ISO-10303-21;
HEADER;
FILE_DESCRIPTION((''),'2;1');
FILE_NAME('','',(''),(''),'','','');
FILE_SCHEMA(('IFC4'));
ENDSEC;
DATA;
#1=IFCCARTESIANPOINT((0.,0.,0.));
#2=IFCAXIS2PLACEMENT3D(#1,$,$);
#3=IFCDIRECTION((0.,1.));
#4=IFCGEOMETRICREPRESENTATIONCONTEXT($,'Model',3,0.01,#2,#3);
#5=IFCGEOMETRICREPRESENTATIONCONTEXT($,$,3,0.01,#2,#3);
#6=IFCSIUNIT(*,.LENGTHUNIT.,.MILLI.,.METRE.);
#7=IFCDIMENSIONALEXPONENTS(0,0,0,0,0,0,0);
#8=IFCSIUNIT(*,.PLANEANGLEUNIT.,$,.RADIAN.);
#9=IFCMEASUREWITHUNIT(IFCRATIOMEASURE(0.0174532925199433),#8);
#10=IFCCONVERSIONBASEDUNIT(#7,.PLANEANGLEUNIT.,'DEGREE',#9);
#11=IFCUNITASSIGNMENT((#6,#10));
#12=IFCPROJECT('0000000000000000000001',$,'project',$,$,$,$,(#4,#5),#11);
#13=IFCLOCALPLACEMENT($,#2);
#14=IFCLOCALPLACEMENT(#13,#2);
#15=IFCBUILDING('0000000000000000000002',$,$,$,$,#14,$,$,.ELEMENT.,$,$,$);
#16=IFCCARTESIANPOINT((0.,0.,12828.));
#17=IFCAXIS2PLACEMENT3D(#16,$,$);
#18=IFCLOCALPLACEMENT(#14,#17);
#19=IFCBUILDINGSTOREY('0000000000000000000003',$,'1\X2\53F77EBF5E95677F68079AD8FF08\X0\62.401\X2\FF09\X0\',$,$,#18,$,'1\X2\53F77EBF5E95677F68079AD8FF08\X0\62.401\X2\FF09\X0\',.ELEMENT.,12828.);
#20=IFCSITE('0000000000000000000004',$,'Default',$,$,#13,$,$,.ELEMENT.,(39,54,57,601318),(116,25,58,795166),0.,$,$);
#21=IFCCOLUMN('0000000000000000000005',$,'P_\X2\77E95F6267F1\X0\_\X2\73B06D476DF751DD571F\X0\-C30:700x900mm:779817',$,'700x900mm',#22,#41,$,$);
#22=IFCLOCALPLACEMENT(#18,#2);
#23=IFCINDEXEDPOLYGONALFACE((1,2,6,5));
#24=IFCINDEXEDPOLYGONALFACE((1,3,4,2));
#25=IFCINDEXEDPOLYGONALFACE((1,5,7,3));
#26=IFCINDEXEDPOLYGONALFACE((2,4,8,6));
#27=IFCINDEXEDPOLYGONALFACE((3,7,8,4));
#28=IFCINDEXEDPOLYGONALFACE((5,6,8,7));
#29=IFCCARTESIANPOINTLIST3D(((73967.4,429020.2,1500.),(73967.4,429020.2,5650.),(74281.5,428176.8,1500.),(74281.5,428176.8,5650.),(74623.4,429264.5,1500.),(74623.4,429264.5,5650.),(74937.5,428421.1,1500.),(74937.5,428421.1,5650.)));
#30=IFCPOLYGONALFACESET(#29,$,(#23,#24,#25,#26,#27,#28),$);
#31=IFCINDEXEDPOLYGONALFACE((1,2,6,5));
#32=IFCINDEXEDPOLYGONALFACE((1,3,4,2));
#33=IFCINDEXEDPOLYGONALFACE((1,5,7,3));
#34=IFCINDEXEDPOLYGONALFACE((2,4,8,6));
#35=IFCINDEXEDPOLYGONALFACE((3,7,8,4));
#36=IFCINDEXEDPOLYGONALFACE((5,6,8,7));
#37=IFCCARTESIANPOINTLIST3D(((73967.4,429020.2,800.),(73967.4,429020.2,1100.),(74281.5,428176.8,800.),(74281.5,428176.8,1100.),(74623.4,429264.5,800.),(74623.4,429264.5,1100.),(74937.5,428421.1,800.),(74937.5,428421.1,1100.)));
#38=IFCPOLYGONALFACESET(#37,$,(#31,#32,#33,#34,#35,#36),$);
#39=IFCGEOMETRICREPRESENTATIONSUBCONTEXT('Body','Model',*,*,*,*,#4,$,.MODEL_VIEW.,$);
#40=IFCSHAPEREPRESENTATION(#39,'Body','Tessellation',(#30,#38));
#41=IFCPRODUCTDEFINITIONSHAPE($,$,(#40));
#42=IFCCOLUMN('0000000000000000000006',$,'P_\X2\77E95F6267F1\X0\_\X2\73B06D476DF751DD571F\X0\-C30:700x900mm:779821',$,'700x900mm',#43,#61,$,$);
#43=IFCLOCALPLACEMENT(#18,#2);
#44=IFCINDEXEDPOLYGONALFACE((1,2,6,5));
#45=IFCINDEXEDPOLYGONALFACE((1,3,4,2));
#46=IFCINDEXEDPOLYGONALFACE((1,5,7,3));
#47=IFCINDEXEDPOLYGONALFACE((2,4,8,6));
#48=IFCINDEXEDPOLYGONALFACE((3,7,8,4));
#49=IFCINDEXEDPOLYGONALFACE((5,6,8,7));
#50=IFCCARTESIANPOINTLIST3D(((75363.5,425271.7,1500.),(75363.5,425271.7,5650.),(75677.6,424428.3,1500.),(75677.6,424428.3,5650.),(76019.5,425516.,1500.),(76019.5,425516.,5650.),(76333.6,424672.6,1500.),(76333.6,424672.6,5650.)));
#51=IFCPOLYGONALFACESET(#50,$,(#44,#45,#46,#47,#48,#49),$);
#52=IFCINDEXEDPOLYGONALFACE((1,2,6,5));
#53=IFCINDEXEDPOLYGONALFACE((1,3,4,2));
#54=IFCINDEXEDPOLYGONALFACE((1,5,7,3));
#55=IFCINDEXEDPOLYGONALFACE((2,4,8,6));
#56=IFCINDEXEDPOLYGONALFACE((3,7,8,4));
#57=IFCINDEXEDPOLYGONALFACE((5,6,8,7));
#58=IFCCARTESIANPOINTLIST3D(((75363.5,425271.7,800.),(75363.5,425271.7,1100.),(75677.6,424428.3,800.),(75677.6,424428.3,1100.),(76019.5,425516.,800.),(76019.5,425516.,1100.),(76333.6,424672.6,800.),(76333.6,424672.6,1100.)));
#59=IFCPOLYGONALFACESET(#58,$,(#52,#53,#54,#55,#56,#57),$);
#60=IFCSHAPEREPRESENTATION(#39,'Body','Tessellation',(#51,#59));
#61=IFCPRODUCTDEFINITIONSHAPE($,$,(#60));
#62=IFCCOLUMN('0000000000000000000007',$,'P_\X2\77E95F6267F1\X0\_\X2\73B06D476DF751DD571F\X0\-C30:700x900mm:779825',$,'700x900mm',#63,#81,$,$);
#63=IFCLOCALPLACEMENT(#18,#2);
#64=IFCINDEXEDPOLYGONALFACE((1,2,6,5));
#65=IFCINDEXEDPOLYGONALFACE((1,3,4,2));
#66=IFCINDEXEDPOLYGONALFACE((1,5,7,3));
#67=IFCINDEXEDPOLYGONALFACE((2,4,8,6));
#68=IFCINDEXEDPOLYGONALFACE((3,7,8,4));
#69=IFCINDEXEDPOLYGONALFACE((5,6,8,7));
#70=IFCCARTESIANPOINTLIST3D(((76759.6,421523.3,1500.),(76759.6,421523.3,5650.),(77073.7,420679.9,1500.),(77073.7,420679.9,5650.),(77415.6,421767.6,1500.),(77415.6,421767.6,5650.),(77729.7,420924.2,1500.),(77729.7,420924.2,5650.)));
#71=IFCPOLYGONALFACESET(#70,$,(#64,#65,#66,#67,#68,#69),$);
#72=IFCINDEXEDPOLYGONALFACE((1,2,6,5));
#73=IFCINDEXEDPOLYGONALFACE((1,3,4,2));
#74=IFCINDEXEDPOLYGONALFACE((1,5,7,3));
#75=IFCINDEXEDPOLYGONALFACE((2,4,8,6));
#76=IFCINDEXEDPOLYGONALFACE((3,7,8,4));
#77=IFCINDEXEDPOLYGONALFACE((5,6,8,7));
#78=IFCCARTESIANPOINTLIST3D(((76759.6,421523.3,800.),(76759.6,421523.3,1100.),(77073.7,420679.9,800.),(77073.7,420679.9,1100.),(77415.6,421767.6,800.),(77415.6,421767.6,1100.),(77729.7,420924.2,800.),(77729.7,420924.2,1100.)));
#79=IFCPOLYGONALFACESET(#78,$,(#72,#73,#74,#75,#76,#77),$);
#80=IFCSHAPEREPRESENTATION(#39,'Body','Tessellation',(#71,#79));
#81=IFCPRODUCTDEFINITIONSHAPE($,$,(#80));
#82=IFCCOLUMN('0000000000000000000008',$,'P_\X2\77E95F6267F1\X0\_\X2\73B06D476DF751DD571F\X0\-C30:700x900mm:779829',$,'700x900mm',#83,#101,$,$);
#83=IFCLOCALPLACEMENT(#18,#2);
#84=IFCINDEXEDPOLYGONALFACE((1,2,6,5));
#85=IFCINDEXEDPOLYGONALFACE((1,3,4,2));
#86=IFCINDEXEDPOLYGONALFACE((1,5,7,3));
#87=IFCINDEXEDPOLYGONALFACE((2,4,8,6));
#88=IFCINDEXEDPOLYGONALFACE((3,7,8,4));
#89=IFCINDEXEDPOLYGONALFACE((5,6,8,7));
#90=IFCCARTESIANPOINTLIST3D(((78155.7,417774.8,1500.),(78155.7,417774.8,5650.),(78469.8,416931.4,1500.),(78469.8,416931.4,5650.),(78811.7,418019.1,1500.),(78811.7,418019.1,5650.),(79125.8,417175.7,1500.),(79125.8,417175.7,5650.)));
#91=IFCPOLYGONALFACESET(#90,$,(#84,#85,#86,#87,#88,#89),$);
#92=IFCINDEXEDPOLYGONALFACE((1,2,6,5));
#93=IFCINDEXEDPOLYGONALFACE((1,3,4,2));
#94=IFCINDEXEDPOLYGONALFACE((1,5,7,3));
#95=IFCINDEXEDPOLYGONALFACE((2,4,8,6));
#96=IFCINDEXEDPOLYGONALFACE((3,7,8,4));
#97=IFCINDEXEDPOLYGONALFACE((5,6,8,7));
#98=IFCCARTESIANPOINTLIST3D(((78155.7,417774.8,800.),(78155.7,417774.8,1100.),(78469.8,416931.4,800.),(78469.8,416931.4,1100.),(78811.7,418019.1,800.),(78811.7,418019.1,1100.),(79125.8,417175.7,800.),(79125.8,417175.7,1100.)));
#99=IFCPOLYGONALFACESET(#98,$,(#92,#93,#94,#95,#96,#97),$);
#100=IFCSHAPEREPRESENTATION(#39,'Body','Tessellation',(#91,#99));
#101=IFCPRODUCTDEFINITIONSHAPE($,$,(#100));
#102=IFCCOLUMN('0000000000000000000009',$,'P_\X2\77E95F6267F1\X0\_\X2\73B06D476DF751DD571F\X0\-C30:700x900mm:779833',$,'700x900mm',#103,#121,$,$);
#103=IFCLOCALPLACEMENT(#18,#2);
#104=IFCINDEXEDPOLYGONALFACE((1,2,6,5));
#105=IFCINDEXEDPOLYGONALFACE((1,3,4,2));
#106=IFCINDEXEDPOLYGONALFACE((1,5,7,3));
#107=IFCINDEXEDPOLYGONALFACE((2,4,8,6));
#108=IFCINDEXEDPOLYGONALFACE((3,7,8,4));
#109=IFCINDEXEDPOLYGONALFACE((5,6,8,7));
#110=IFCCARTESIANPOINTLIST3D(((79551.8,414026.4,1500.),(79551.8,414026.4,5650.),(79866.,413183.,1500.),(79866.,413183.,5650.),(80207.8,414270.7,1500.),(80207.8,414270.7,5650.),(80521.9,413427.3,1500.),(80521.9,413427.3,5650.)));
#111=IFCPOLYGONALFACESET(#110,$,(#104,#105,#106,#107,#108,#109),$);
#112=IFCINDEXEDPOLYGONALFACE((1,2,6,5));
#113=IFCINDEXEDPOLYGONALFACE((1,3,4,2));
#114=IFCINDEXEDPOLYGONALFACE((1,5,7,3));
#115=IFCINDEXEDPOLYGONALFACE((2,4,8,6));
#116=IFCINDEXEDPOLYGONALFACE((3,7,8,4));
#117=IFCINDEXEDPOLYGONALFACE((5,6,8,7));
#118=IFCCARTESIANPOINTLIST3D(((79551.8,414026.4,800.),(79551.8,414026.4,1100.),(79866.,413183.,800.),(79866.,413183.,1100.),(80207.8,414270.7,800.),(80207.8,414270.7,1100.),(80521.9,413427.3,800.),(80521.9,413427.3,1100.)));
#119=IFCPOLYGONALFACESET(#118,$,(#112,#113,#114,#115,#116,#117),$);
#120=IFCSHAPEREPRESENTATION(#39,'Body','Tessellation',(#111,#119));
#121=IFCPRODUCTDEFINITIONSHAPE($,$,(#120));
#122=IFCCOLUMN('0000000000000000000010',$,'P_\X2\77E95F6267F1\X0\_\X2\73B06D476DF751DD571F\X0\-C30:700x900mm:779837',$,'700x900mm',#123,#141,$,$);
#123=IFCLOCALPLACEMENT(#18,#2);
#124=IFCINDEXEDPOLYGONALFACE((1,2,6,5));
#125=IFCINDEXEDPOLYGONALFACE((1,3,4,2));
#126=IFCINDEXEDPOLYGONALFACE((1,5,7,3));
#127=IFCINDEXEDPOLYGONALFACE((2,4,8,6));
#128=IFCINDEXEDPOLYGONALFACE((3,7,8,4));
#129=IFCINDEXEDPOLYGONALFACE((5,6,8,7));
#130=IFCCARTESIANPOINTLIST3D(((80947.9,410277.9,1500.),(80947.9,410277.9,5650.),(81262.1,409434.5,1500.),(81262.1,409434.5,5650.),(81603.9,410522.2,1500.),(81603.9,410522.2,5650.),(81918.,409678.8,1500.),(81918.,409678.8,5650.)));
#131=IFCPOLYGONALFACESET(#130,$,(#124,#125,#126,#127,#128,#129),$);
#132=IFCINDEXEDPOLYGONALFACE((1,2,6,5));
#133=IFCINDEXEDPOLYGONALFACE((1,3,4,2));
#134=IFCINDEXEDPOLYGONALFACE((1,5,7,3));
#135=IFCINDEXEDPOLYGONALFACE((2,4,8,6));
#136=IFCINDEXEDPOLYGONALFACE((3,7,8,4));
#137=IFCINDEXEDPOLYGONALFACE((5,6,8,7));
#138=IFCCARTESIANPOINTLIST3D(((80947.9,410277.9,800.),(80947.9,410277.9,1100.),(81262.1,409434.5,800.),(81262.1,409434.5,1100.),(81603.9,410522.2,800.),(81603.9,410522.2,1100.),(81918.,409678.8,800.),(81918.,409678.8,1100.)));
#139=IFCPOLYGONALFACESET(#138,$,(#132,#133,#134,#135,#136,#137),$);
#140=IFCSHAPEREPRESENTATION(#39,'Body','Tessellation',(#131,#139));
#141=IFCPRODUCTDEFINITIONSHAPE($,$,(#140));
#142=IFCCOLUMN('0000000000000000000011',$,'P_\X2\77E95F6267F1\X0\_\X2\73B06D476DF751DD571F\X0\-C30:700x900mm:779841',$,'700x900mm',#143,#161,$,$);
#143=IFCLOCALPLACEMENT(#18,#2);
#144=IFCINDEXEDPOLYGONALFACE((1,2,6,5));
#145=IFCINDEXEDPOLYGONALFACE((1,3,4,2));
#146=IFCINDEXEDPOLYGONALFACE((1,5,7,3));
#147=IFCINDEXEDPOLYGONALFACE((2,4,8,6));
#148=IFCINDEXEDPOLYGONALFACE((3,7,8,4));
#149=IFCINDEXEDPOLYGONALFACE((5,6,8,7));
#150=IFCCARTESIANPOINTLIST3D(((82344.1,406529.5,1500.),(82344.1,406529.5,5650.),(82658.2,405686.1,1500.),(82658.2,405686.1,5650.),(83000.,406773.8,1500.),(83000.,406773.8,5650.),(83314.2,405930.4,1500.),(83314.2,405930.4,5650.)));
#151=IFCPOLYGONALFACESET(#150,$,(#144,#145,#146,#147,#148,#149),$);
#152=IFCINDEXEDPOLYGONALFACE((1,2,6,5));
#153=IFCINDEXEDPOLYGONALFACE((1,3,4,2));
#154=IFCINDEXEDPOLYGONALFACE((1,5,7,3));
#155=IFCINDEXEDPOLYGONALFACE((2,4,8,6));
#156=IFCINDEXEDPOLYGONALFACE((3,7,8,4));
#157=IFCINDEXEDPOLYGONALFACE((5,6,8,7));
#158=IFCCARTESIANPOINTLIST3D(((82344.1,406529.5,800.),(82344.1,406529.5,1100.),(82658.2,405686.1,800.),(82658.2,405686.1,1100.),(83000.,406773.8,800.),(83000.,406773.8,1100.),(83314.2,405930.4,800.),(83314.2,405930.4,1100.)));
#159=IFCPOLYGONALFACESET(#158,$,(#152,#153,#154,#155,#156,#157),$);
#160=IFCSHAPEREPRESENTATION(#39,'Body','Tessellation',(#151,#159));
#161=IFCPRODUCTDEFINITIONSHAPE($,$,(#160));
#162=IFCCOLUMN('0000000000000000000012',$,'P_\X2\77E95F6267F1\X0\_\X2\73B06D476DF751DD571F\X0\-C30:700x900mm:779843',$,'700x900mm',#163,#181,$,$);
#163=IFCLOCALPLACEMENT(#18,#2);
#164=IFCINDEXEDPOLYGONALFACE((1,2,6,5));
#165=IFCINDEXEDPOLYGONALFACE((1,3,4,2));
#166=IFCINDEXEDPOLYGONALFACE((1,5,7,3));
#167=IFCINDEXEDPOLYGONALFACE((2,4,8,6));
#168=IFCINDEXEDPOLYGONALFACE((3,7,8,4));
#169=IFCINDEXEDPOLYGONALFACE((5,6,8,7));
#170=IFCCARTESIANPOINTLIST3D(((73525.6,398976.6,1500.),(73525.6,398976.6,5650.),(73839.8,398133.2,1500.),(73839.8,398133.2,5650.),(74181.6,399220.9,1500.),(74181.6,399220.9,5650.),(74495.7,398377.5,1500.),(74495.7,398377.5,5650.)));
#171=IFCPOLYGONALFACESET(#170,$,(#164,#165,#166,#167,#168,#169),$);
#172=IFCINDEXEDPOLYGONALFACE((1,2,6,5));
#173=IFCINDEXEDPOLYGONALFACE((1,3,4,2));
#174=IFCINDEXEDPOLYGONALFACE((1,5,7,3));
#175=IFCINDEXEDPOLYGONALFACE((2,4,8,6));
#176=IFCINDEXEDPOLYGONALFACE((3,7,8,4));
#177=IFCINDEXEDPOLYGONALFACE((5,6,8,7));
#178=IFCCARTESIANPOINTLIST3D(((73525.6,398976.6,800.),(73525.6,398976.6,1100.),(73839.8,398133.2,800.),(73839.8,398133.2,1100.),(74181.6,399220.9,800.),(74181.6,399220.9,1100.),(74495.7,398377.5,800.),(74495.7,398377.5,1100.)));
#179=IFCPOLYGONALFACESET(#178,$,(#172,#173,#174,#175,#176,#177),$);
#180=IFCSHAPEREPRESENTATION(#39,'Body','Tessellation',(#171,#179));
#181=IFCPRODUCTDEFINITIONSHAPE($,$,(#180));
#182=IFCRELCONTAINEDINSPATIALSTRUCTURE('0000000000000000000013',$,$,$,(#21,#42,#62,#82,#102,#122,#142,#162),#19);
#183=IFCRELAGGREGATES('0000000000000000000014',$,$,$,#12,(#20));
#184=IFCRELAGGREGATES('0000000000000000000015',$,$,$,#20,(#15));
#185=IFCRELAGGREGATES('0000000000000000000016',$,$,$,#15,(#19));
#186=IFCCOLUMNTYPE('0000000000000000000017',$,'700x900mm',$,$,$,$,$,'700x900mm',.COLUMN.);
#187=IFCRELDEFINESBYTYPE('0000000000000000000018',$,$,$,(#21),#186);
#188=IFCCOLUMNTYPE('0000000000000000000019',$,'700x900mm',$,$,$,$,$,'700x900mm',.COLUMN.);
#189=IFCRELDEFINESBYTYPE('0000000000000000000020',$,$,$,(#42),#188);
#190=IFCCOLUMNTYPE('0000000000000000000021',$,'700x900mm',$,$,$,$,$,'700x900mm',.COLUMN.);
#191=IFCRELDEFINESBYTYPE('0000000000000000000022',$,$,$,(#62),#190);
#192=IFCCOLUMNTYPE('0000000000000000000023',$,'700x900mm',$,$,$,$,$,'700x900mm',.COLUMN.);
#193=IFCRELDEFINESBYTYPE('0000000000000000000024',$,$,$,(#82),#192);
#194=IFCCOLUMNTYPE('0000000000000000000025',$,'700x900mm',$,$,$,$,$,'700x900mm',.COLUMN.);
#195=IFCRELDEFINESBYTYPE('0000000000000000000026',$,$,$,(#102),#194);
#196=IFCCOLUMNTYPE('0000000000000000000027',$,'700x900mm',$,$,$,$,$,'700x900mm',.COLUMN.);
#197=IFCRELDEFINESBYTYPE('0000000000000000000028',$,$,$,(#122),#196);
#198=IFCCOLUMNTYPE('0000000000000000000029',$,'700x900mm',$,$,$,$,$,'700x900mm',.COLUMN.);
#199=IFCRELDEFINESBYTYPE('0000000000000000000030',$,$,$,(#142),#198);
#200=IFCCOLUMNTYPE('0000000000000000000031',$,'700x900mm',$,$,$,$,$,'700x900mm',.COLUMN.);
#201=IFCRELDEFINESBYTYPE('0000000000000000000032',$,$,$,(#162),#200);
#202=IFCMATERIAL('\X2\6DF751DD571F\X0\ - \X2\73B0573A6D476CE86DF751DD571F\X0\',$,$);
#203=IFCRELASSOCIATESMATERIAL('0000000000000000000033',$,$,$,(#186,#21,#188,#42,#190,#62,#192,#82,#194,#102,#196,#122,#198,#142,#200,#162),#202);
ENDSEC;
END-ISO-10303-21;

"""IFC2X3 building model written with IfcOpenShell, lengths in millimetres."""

from ifc_helpers import new_model, entity, si_unit, converted_unit, direction, frame, frame_2d, origin, origin_2d_with_axis, place, context, subcontext, project, spatial, rectangle, extrude, source, transform, mapped, material, type_object, type_shapes, element, save


model = new_model("IFC2X3")

# Units and contexts
model_context = context("Model", 3, precision=0.01, world=origin(), true_north=direction((0.0, 1.0)))
context_of_model = context(None, 3, precision=0.01, world=origin(), true_north=direction((0.0, 1.0)))
body_context = subcontext(model_context, "Body", "Model", "MODEL_VIEW")
ifc_project = project(units=[si_unit("LENGTHUNIT", "METRE", prefix="MILLI"), converted_unit("PLANEANGLEUNIT", "DEGREE", entity("IfcRatioMeasure", 0.0174532925199433), si_unit("PLANEANGLEUNIT", "RADIAN"), dimensions=[0, 0, 0, 0, 0, 0, 0])], contexts=[model_context, context_of_model])

# Site, building, storey
site_placement = place(None, origin())
site = spatial("IfcSite", under=ifc_project, at=site_placement, Name="Default", CompositionType="ELEMENT", RefLatitude=(39, 54, 57, 601318), RefLongitude=(116, 25, 58, 795166), RefElevation=0.0)
building_placement = place(site_placement, origin())
building = spatial("IfcBuilding", under=site, at=building_placement, CompositionType="ELEMENT")
storey_placement = place(building_placement, frame((0.0, 0.0, 12828.0)))
storey = spatial("IfcBuildingStorey", under=building, at=storey_placement, Name="1号线底板标高（62.401）", LongName="1号线底板标高（62.401）", CompositionType="ELEMENT", Elevation=12828.0)

# Columns
ifc_material_1 = material(Name="混凝土 - 现场浇注混凝土")
column_type_1 = type_object("IfcColumnType", Name="700x900mm", ElementType="700x900mm", PredefinedType="COLUMN", material=ifc_material_1)
shared_shape_1 = source(origin(), body_context, "Body", "SweptSolid", [
    extrude(rectangle(XDim=700.0, YDim=900.0, at=frame_2d((0.0, 0.0), x_axis=(1.0, 0.0))), frame((485.1, 543.9, 700.0), z_axis=(0.0, 0.0, 1.0), x_axis=(-0.937112, -0.349028, 0.0)), (0.0, 0.0, 1.0), 4150.0),
    extrude(rectangle(XDim=700.0, YDim=900.0, at=frame_2d((0.0, 0.0), x_axis=(1.0, 0.0))), frame((485.1, 543.9, 0.0), z_axis=(0.0, 0.0, 1.0), x_axis=(-0.937112, -0.349028, 0.0)), (0.0, 0.0, 1.0), 300.0),
])
type_shapes(column_type_1, [shared_shape_1])
column_1_placement = place(storey_placement, frame((73967.4, 428176.8, 800.0)))
element("IfcColumn", 1, at=column_1_placement, inside=storey, type_object=column_type_1, material=ifc_material_1, Name="P_矩形柱_现浇混凝土-C30:700x900mm:779817", ObjectType="700x900mm", context=body_context, shape_type="MappedRepresentation", body=[
    mapped(shared_shape_1, transform((0.0, 0.0, 0.0), scale=1.0)),
])
column_type_2 = type_object("IfcColumnType", Name="700x900mm", ElementType="700x900mm", PredefinedType="COLUMN", material=ifc_material_1)
shared_shape_2 = source(origin(), body_context, "Body", "SweptSolid", [
    extrude(rectangle(XDim=700.0, YDim=900.0, at=frame_2d((0.0, 0.0), x_axis=(1.0, 0.0))), frame((485.1, 543.9, 700.0), z_axis=(0.0, 0.0, 1.0), x_axis=(-0.937112, -0.349028, 0.0)), (0.0, 0.0, 1.0), 4150.0),
    extrude(rectangle(XDim=700.0, YDim=900.0, at=frame_2d((0.0, 0.0), x_axis=(1.0, 0.0))), frame((485.1, 543.9, 0.0), z_axis=(0.0, 0.0, 1.0), x_axis=(-0.937112, -0.349028, 0.0)), (0.0, 0.0, 1.0), 300.0),
])
type_shapes(column_type_2, [shared_shape_2])
column_2_placement = place(storey_placement, frame((75363.5, 424428.3, 800.0)))
element("IfcColumn", 2, at=column_2_placement, inside=storey, type_object=column_type_2, material=ifc_material_1, Name="P_矩形柱_现浇混凝土-C30:700x900mm:779821", ObjectType="700x900mm", context=body_context, shape_type="MappedRepresentation", body=[
    mapped(shared_shape_2, transform((0.0, 0.0, 0.0), scale=1.0)),
])
column_type_3 = type_object("IfcColumnType", Name="700x900mm", ElementType="700x900mm", PredefinedType="COLUMN", material=ifc_material_1)
shared_shape_3 = source(origin(), body_context, "Body", "SweptSolid", [
    extrude(rectangle(XDim=700.0, YDim=900.0, at=frame_2d((0.0, 0.0), x_axis=(1.0, 0.0))), frame((485.1, 543.9, 700.0), z_axis=(0.0, 0.0, 1.0), x_axis=(-0.937112, -0.349028, 0.0)), (0.0, 0.0, 1.0), 4150.0),
    extrude(rectangle(XDim=700.0, YDim=900.0, at=frame_2d((0.0, 0.0), x_axis=(1.0, 0.0))), frame((485.1, 543.9, 0.0), z_axis=(0.0, 0.0, 1.0), x_axis=(-0.937112, -0.349028, 0.0)), (0.0, 0.0, 1.0), 300.0),
])
type_shapes(column_type_3, [shared_shape_3])
column_3_placement = place(storey_placement, frame((76759.6, 420679.9, 800.0)))
element("IfcColumn", 3, at=column_3_placement, inside=storey, type_object=column_type_3, material=ifc_material_1, Name="P_矩形柱_现浇混凝土-C30:700x900mm:779825", ObjectType="700x900mm", context=body_context, shape_type="MappedRepresentation", body=[
    mapped(shared_shape_3, transform((0.0, 0.0, 0.0), scale=1.0)),
])
column_type_4 = type_object("IfcColumnType", Name="700x900mm", ElementType="700x900mm", PredefinedType="COLUMN", material=ifc_material_1)
shared_shape_4 = source(origin(), body_context, "Body", "SweptSolid", [
    extrude(rectangle(XDim=700.0, YDim=900.0, at=frame_2d((0.0, 0.0), x_axis=(1.0, 0.0))), frame((485.1, 543.9, 700.0), z_axis=(0.0, 0.0, 1.0), x_axis=(-0.937112, -0.349028, 0.0)), (0.0, 0.0, 1.0), 4150.0),
    extrude(rectangle(XDim=700.0, YDim=900.0, at=frame_2d((0.0, 0.0), x_axis=(1.0, 0.0))), frame((485.1, 543.9, 0.0), z_axis=(0.0, 0.0, 1.0), x_axis=(-0.937112, -0.349028, 0.0)), (0.0, 0.0, 1.0), 300.0),
])
type_shapes(column_type_4, [shared_shape_4])
column_4_placement = place(storey_placement, frame((78155.7, 416931.4, 800.0)))
element("IfcColumn", 4, at=column_4_placement, inside=storey, type_object=column_type_4, material=ifc_material_1, Name="P_矩形柱_现浇混凝土-C30:700x900mm:779829", ObjectType="700x900mm", context=body_context, shape_type="MappedRepresentation", body=[
    mapped(shared_shape_4, transform((0.0, 0.0, 0.0), scale=1.0)),
])
column_type_5 = type_object("IfcColumnType", Name="700x900mm", ElementType="700x900mm", PredefinedType="COLUMN", material=ifc_material_1)
shared_shape_5 = source(origin(), body_context, "Body", "SweptSolid", [
    extrude(rectangle(XDim=700.0, YDim=900.0, at=frame_2d((0.0, 0.0), x_axis=(1.0, 0.0))), frame((485.1, 543.9, 700.0), z_axis=(0.0, 0.0, 1.0), x_axis=(-0.937112, -0.349028, 0.0)), (0.0, 0.0, 1.0), 4150.0),
    extrude(rectangle(XDim=700.0, YDim=900.0, at=frame_2d((0.0, 0.0), x_axis=(1.0, 0.0))), frame((485.1, 543.9, 0.0), z_axis=(0.0, 0.0, 1.0), x_axis=(-0.937112, -0.349028, 0.0)), (0.0, 0.0, 1.0), 300.0),
])
type_shapes(column_type_5, [shared_shape_5])
column_5_placement = place(storey_placement, frame((79551.8, 413183.0, 800.0)))
element("IfcColumn", 5, at=column_5_placement, inside=storey, type_object=column_type_5, material=ifc_material_1, Name="P_矩形柱_现浇混凝土-C30:700x900mm:779833", ObjectType="700x900mm", context=body_context, shape_type="MappedRepresentation", body=[
    mapped(shared_shape_5, transform((0.0, 0.0, 0.0), scale=1.0)),
])
column_type_6 = type_object("IfcColumnType", Name="700x900mm", ElementType="700x900mm", PredefinedType="COLUMN", material=ifc_material_1)
shared_shape_6 = source(origin(), body_context, "Body", "SweptSolid", [
    extrude(rectangle(XDim=700.0, YDim=900.0, at=frame_2d((0.0, 0.0), x_axis=(1.0, 0.0))), frame((485.1, 543.9, 700.0), z_axis=(0.0, 0.0, 1.0), x_axis=(-0.937112, -0.349028, 0.0)), (0.0, 0.0, 1.0), 4150.0),
    extrude(rectangle(XDim=700.0, YDim=900.0, at=frame_2d((0.0, 0.0), x_axis=(1.0, 0.0))), frame((485.1, 543.9, 0.0), z_axis=(0.0, 0.0, 1.0), x_axis=(-0.937112, -0.349028, 0.0)), (0.0, 0.0, 1.0), 300.0),
])
type_shapes(column_type_6, [shared_shape_6])
column_6_placement = place(storey_placement, frame((80947.9, 409434.5, 800.0)))
element("IfcColumn", 6, at=column_6_placement, inside=storey, type_object=column_type_6, material=ifc_material_1, Name="P_矩形柱_现浇混凝土-C30:700x900mm:779837", ObjectType="700x900mm", context=body_context, shape_type="MappedRepresentation", body=[
    mapped(shared_shape_6, transform((0.0, 0.0, 0.0), scale=1.0)),
])
column_type_7 = type_object("IfcColumnType", Name="700x900mm", ElementType="700x900mm", PredefinedType="COLUMN", material=ifc_material_1)
shared_shape_7 = source(origin(), body_context, "Body", "SweptSolid", [
    extrude(rectangle(XDim=700.0, YDim=900.0, at=origin_2d_with_axis()), frame((485.1, 543.9, 700.0), z_axis=(0.0, 0.0, 1.0), x_axis=(-0.937112, -0.349028, 0.0)), (0.0, 0.0, 1.0), 4150.0),
    extrude(rectangle(XDim=700.0, YDim=900.0, at=origin_2d_with_axis()), frame((485.1, 543.9, 0.0), z_axis=(0.0, 0.0, 1.0), x_axis=(-0.937112, -0.349028, 0.0)), (0.0, 0.0, 1.0), 300.0),
])
type_shapes(column_type_7, [shared_shape_7])
column_7_placement = place(storey_placement, frame((82344.1, 405686.1, 800.0)))
element("IfcColumn", 7, at=column_7_placement, inside=storey, type_object=column_type_7, material=ifc_material_1, Name="P_矩形柱_现浇混凝土-C30:700x900mm:779841", ObjectType="700x900mm", context=body_context, shape_type="MappedRepresentation", body=[
    mapped(shared_shape_7, transform((0.0, 0.0, 0.0), scale=1.0)),
])
column_type_8 = type_object("IfcColumnType", Name="700x900mm", ElementType="700x900mm", PredefinedType="COLUMN", material=ifc_material_1)
shared_shape_8 = source(origin(), body_context, "Body", "SweptSolid", [
    extrude(rectangle(XDim=700.0, YDim=900.0, at=frame_2d((0.0, 0.0), x_axis=(1.0, 0.0))), frame((485.1, 543.9, 700.0), z_axis=(0.0, 0.0, 1.0), x_axis=(-0.937112, -0.349028, 0.0)), (0.0, 0.0, 1.0), 4150.0),
    extrude(rectangle(XDim=700.0, YDim=900.0, at=frame_2d((0.0, 0.0), x_axis=(1.0, 0.0))), frame((485.1, 543.9, 0.0), z_axis=(0.0, 0.0, 1.0), x_axis=(-0.937112, -0.349028, 0.0)), (0.0, 0.0, 1.0), 300.0),
])
type_shapes(column_type_8, [shared_shape_8])
column_8_placement = place(storey_placement, frame((73525.6, 398133.2, 800.0)))
element("IfcColumn", 8, at=column_8_placement, inside=storey, type_object=column_type_8, material=ifc_material_1, Name="P_矩形柱_现浇混凝土-C30:700x900mm:779843", ObjectType="700x900mm", context=body_context, shape_type="MappedRepresentation", body=[
    mapped(shared_shape_8, transform((0.0, 0.0, 0.0), scale=1.0)),
])

save(model, "model.ifc")
